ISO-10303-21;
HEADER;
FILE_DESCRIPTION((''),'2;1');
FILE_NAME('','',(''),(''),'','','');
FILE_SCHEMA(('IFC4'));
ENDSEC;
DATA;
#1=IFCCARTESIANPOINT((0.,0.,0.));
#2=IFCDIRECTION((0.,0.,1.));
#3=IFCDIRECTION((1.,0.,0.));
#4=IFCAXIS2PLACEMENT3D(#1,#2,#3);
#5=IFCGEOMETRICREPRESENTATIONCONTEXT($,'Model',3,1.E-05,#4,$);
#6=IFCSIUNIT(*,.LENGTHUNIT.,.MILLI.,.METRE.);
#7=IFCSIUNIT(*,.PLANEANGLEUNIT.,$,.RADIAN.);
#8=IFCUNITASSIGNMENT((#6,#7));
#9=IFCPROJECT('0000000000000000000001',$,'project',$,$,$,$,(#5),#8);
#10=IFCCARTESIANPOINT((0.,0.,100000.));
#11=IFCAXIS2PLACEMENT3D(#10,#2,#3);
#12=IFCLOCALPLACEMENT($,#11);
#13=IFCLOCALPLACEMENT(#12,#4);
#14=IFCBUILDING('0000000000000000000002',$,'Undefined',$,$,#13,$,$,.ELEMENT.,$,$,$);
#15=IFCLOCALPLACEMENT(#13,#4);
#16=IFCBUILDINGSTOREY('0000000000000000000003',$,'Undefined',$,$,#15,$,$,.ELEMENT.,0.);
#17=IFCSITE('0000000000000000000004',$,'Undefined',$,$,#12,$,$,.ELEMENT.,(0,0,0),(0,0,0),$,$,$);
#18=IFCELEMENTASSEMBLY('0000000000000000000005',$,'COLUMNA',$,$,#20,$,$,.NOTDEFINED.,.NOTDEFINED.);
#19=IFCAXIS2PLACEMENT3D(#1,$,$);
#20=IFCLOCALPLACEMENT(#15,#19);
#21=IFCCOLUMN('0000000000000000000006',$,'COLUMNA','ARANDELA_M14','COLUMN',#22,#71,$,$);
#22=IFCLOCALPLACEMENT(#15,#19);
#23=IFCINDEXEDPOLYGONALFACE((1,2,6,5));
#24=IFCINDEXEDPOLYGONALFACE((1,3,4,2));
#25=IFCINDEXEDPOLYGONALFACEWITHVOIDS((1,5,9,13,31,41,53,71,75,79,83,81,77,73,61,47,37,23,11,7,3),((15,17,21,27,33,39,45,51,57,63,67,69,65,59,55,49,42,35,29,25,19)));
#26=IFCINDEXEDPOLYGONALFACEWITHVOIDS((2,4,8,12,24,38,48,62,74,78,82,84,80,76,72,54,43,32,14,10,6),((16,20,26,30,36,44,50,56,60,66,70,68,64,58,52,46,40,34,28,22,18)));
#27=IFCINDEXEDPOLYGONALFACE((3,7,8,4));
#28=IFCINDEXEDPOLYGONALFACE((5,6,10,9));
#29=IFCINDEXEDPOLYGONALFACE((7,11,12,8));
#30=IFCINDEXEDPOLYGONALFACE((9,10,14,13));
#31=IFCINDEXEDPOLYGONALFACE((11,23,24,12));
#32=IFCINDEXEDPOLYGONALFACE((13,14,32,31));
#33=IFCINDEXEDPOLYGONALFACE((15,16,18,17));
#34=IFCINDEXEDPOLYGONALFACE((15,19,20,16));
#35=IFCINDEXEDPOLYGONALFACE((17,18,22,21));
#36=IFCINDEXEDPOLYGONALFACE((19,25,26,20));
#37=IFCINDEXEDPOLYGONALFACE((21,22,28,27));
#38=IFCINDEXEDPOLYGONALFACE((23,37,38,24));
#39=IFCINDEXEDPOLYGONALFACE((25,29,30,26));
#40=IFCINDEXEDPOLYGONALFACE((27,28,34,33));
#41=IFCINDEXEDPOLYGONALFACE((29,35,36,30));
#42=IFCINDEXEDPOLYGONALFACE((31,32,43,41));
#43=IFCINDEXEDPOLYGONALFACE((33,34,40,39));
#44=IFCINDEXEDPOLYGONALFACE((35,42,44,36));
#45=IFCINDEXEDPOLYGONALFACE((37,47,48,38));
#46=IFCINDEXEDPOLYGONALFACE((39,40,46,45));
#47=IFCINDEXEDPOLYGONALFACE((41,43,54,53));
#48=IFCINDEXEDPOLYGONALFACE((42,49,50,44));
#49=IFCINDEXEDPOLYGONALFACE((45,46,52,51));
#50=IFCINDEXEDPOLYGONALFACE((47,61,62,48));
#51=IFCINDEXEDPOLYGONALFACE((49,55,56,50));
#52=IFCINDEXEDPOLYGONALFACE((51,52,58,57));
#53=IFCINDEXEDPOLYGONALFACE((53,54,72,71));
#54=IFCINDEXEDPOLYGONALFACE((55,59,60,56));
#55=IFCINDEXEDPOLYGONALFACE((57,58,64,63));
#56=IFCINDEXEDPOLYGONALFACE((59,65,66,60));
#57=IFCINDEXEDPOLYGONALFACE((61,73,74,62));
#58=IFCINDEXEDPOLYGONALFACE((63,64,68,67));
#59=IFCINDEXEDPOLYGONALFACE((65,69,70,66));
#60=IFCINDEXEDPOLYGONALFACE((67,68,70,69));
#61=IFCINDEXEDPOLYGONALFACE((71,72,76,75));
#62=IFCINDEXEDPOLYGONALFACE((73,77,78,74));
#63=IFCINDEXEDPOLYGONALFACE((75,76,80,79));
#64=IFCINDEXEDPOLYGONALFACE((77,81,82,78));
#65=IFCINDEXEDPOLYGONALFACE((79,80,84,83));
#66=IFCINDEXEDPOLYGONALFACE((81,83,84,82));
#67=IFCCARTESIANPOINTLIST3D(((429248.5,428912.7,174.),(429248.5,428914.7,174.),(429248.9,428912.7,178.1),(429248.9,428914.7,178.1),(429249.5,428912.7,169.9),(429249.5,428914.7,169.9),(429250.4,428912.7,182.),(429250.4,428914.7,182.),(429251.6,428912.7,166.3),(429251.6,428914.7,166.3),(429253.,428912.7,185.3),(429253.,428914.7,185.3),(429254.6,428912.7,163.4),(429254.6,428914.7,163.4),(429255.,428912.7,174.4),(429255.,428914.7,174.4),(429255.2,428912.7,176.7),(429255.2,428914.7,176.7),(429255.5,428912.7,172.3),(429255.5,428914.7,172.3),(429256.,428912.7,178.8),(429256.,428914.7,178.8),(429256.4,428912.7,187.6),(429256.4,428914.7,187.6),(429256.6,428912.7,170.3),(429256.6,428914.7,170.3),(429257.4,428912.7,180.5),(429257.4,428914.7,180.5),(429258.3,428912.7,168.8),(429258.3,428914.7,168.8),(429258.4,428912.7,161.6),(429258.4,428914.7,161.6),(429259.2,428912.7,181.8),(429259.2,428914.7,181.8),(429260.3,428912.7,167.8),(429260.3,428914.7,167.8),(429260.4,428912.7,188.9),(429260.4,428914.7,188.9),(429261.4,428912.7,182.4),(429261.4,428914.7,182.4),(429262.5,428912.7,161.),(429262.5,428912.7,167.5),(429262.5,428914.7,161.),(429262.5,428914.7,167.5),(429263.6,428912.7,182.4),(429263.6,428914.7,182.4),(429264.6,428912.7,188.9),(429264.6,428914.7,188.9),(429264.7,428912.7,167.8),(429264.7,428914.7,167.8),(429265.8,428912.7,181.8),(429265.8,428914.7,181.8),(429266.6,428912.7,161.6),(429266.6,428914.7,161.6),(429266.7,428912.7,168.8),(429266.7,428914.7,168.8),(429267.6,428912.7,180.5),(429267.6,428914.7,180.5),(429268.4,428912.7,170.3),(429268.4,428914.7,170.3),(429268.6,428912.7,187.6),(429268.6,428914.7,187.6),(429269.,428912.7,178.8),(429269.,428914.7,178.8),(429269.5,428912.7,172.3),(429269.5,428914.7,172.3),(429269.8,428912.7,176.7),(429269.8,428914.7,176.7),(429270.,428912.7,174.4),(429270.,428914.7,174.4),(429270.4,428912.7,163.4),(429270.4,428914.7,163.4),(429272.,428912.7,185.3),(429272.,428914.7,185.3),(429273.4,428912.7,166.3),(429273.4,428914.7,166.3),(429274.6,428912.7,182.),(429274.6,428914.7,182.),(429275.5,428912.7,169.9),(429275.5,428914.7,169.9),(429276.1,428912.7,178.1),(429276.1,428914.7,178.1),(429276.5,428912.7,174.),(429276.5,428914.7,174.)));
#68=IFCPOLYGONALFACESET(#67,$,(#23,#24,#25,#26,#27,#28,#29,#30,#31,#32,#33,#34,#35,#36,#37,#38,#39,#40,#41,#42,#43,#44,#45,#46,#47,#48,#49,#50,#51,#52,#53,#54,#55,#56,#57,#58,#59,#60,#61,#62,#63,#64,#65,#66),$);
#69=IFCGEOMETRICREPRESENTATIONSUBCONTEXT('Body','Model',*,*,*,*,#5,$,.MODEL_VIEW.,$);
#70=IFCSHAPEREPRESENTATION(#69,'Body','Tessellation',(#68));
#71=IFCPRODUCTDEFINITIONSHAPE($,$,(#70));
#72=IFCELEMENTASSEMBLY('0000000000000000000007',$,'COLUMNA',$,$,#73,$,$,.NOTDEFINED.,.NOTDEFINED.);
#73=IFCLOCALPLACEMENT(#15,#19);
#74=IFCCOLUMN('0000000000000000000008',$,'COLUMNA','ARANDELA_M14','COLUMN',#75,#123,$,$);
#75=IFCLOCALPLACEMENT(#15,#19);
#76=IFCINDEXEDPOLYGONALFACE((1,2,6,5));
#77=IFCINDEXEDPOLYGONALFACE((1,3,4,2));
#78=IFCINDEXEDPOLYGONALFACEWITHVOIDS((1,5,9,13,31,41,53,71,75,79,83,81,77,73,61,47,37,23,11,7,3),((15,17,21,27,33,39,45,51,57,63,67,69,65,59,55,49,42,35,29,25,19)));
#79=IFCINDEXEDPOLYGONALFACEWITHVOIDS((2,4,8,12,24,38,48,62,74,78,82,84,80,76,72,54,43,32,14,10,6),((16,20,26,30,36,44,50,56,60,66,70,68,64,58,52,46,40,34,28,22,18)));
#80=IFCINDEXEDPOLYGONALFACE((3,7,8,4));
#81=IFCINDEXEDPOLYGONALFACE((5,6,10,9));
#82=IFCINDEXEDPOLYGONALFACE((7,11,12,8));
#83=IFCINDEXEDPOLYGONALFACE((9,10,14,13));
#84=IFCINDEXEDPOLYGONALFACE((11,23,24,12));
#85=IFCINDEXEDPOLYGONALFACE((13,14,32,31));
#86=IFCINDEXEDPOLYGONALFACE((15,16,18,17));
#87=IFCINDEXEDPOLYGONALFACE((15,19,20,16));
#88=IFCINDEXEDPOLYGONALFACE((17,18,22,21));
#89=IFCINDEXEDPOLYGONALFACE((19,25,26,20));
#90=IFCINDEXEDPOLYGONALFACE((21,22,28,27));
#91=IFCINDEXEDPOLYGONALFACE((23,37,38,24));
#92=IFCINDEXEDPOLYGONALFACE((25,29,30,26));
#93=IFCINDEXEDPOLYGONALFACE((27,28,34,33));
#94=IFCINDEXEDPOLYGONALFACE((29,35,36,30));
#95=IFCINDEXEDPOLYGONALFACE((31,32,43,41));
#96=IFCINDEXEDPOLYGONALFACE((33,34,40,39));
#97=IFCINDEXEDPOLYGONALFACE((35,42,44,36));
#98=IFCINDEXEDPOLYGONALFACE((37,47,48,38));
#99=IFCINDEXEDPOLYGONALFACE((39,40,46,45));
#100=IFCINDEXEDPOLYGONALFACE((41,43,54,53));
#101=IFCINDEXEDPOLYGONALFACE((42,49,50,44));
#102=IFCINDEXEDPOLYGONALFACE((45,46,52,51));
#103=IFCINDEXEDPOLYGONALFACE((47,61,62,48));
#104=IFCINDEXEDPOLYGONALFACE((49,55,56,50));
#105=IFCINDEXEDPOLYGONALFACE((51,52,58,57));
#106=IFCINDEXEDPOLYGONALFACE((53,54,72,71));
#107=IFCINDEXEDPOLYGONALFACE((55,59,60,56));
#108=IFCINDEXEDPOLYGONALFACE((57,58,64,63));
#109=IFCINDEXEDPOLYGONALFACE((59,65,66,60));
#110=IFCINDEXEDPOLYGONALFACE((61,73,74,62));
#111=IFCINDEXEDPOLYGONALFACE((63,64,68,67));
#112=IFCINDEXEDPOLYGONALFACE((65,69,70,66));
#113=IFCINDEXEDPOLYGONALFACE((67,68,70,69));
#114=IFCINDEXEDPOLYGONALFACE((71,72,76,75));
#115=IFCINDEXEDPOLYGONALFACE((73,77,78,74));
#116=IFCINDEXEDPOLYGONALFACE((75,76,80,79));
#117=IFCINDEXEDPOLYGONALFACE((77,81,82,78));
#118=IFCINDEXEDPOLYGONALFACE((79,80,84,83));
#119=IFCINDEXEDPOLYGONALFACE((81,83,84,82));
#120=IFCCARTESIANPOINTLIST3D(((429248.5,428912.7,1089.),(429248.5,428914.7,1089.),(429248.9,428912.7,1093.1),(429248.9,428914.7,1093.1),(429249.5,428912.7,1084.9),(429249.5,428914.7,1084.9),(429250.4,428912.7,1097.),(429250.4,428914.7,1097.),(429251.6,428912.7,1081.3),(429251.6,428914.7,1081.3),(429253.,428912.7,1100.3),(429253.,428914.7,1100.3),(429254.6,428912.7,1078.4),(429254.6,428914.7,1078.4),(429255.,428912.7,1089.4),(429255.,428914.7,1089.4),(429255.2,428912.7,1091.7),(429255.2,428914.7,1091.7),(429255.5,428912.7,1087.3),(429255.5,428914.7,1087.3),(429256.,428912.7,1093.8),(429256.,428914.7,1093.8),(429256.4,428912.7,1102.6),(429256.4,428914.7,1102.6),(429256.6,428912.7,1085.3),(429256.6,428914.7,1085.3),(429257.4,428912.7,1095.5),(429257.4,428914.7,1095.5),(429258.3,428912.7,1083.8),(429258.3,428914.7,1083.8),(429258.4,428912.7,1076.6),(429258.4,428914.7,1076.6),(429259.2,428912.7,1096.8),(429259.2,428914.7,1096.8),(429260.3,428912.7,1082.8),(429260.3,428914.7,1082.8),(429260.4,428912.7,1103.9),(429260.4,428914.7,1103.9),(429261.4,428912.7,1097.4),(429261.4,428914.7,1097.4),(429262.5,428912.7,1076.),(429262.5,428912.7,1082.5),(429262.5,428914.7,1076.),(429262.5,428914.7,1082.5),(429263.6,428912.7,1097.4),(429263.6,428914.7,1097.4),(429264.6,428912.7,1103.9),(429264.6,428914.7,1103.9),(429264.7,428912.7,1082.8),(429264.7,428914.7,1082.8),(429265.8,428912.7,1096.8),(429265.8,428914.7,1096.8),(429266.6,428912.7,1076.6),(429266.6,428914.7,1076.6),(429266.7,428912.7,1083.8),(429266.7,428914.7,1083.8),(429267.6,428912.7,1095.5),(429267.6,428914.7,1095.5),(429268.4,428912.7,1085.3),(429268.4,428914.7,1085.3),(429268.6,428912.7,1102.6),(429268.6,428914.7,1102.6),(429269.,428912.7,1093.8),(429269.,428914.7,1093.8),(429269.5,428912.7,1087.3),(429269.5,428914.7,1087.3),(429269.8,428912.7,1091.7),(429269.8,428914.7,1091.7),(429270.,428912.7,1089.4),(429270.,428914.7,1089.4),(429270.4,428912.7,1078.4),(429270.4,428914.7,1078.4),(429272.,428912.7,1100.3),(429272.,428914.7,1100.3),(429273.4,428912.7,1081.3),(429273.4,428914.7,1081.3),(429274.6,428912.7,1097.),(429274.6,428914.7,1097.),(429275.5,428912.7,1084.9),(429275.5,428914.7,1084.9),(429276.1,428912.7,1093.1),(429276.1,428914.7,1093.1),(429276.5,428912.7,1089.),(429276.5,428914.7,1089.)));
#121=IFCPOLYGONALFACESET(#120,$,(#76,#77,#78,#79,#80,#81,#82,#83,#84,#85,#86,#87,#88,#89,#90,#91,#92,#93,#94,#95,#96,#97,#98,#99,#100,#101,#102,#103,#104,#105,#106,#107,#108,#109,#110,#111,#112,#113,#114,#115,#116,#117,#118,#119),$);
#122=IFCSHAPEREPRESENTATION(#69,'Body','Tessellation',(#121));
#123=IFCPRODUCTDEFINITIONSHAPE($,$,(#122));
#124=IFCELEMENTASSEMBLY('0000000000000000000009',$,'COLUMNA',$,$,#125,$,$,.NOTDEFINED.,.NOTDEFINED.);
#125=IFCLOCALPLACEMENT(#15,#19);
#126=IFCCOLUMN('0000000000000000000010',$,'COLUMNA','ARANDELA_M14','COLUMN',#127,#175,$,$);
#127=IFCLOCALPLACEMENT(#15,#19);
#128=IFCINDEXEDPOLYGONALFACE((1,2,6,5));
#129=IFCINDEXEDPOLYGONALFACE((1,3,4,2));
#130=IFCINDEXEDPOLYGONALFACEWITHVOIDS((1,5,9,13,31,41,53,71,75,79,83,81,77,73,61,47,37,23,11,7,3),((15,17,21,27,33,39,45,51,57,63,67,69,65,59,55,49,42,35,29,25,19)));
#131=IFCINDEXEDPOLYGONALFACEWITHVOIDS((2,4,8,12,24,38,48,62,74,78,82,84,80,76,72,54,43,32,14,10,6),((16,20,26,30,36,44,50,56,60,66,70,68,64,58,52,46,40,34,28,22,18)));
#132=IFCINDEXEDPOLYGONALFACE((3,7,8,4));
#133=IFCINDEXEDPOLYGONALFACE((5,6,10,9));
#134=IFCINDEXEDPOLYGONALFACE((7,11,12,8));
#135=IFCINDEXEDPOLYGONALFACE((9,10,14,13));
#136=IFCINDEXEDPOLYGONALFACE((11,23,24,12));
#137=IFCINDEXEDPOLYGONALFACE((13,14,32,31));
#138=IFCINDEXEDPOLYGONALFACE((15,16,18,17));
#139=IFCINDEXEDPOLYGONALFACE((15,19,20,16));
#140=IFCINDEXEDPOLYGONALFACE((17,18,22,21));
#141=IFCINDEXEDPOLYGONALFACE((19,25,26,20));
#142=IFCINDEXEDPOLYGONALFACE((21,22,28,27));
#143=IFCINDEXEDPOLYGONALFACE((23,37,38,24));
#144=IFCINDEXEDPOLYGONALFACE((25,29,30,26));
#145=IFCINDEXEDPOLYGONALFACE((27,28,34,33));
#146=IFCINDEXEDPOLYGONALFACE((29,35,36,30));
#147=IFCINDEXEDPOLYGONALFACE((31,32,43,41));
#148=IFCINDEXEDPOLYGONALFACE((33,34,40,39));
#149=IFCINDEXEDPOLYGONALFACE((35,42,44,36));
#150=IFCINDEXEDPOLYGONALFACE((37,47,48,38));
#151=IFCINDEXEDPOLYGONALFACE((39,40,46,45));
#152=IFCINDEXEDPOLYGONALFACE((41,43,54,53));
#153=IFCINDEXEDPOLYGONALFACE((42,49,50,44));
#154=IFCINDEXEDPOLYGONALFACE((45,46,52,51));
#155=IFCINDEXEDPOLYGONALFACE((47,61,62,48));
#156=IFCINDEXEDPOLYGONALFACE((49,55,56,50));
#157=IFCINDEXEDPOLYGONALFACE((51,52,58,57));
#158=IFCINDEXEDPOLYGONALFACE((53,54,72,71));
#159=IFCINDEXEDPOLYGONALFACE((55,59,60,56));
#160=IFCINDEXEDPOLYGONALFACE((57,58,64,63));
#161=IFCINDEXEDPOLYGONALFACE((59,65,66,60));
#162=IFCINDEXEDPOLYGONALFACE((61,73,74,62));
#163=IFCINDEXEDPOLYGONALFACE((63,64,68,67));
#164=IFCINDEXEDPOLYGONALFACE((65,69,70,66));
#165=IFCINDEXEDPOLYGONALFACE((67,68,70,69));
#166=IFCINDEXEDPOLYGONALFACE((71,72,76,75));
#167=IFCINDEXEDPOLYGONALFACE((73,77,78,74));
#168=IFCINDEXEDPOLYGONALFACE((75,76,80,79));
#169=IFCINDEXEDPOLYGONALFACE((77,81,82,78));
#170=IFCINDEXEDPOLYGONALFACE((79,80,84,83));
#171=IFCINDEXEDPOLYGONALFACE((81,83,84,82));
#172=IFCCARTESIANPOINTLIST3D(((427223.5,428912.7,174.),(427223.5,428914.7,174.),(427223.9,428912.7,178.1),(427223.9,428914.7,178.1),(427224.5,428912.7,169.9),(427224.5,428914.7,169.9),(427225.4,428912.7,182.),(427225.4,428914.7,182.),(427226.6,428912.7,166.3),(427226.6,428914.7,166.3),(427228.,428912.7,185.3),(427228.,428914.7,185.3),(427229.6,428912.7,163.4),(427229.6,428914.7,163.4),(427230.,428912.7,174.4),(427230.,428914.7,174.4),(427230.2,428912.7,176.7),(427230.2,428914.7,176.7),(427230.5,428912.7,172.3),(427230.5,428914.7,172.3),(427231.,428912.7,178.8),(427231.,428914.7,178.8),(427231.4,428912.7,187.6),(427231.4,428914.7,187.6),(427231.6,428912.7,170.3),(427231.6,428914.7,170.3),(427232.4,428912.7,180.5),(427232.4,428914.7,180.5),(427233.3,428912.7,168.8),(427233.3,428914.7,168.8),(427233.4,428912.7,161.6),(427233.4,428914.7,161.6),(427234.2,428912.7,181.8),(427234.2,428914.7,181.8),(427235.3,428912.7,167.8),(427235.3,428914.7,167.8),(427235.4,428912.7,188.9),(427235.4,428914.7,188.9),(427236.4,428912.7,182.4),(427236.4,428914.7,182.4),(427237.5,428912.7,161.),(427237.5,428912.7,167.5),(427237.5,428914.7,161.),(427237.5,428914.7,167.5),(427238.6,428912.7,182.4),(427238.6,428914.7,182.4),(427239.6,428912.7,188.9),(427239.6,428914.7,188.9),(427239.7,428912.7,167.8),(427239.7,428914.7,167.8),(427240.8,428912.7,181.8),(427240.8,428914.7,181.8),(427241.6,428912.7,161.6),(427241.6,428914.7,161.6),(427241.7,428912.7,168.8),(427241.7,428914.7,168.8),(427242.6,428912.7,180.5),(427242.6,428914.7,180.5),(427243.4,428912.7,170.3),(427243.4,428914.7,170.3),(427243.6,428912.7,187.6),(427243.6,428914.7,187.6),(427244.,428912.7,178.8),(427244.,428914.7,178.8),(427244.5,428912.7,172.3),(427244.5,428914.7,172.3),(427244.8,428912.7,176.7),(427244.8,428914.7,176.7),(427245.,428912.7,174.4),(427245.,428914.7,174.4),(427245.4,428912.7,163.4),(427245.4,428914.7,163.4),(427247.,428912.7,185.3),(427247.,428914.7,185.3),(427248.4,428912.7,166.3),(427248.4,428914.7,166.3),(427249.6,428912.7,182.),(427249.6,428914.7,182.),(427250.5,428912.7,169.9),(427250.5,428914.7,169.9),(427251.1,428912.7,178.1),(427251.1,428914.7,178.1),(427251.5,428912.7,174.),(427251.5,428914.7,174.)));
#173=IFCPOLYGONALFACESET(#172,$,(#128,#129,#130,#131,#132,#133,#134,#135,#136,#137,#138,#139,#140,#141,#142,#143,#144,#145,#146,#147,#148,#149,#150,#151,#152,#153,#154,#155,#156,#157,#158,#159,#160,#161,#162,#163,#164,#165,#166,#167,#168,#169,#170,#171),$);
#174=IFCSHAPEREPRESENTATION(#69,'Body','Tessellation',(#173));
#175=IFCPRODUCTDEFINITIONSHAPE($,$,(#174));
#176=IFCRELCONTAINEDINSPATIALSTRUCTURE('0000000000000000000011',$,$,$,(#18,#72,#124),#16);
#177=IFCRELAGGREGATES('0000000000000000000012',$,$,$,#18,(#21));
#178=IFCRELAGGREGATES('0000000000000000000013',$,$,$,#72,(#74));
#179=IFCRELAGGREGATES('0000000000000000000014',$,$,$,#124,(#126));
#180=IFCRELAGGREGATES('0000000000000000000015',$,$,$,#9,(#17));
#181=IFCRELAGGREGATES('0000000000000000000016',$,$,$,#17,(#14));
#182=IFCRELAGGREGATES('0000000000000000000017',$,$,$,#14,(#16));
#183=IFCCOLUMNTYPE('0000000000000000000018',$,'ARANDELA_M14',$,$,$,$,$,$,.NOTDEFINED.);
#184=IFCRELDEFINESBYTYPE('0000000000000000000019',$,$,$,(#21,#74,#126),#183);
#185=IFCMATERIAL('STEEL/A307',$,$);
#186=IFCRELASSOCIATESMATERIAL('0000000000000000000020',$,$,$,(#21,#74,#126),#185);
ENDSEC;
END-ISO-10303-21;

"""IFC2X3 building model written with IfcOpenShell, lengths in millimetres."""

from ifc_helpers import new_model, si_unit, frame, origin_with_axes, origin_2d_with_axis, place, context, subcontext, project, spatial, hollow_circle, extrude, material, type_object, element, aggregate, save


model = new_model("IFC2X3")

# Units and contexts
model_context = context("Model", 3, precision=1e-05, world=origin_with_axes())
body_context = subcontext(model_context, "Body", "Model", "MODEL_VIEW")
ifc_project = project(units=[si_unit("LENGTHUNIT", "METRE", prefix="MILLI"), si_unit("PLANEANGLEUNIT", "RADIAN")], contexts=[model_context])

# Site, building, storey
site_placement = place(None, frame((0.0, 0.0, 100000.0), z_axis=(0.0, 0.0, 1.0), x_axis=(1.0, 0.0, 0.0)))
site = spatial("IfcSite", under=ifc_project, at=site_placement, Name="Undefined", CompositionType="ELEMENT", RefLatitude=(0, 0, 0), RefLongitude=(0, 0, 0))
building_placement = place(site_placement, origin_with_axes())
building = spatial("IfcBuilding", under=site, at=building_placement, Name="Undefined", CompositionType="ELEMENT")
storey_placement = place(building_placement, origin_with_axes())
storey = spatial("IfcBuildingStorey", under=building, at=storey_placement, Name="Undefined", CompositionType="ELEMENT", Elevation=0.0)

# Element assemblies, columns
ifc_material_1 = material(Name="STEEL/A307")
column_type_1 = type_object("IfcColumnType", Name="ARANDELA_M14", PredefinedType="NOTDEFINED")
assembly_1_placement = place(storey_placement, origin_with_axes())
assembly_1 = element("IfcElementAssembly", 1, at=assembly_1_placement, inside=storey, Name="COLUMNA", AssemblyPlace="NOTDEFINED", PredefinedType="NOTDEFINED")
column_1_placement = place(assembly_1_placement, frame((429262.5, 428912.7, 175.0), z_axis=(0.0, 1.0, 0.000285), x_axis=(1.0, 0.0, 0.0)))
column_1 = element("IfcColumn", 2, at=column_1_placement, type_object=column_type_1, material=ifc_material_1, Name="COLUMNA", Description="ARANDELA_M14", ObjectType="COLUMN", context=body_context, shape_type="SweptSolid", body=[
    extrude(hollow_circle(Radius=14.0, WallThickness=6.5, at=origin_2d_with_axis()), frame((0.0, 0.0, 2.0), z_axis=(0.0, 0.0, -1.0), x_axis=(0.0, 1.0, 0.0)), (0.0, 0.0, 1.0), 2.0),
])
aggregate(assembly_1, [column_1])
assembly_2_placement = place(storey_placement, origin_with_axes())
assembly_2 = element("IfcElementAssembly", 3, at=assembly_2_placement, inside=storey, Name="COLUMNA", AssemblyPlace="NOTDEFINED", PredefinedType="NOTDEFINED")
column_2_placement = place(assembly_2_placement, frame((429262.5, 428912.7, 1090.0), z_axis=(0.0, 1.0, 0.000285), x_axis=(1.0, 0.0, 0.0)))
column_2 = element("IfcColumn", 4, at=column_2_placement, type_object=column_type_1, material=ifc_material_1, Name="COLUMNA", Description="ARANDELA_M14", ObjectType="COLUMN", context=body_context, shape_type="SweptSolid", body=[
    extrude(hollow_circle(Radius=14.0, WallThickness=6.5, at=origin_2d_with_axis()), frame((0.0, 0.0, 2.0), z_axis=(0.0, 0.0, -1.0), x_axis=(0.0, 1.0, 0.0)), (0.0, 0.0, 1.0), 2.0),
])
aggregate(assembly_2, [column_2])
assembly_3_placement = place(storey_placement, origin_with_axes())
assembly_3 = element("IfcElementAssembly", 5, at=assembly_3_placement, inside=storey, Name="COLUMNA", AssemblyPlace="NOTDEFINED", PredefinedType="NOTDEFINED")
column_3_placement = place(assembly_3_placement, frame((427237.5, 428912.7, 175.0), z_axis=(0.0, 1.0, 0.000285), x_axis=(1.0, 0.0, 0.0)))
column_3 = element("IfcColumn", 6, at=column_3_placement, type_object=column_type_1, material=ifc_material_1, Name="COLUMNA", Description="ARANDELA_M14", ObjectType="COLUMN", context=body_context, shape_type="SweptSolid", body=[
    extrude(hollow_circle(Radius=14.0, WallThickness=6.5, at=origin_2d_with_axis()), frame((0.0, 0.0, 2.0), z_axis=(0.0, 0.0, -1.0), x_axis=(0.0, 1.0, 0.0)), (0.0, 0.0, 1.0), 2.0),
])
aggregate(assembly_3, [column_3])

save(model, "model.ifc")
